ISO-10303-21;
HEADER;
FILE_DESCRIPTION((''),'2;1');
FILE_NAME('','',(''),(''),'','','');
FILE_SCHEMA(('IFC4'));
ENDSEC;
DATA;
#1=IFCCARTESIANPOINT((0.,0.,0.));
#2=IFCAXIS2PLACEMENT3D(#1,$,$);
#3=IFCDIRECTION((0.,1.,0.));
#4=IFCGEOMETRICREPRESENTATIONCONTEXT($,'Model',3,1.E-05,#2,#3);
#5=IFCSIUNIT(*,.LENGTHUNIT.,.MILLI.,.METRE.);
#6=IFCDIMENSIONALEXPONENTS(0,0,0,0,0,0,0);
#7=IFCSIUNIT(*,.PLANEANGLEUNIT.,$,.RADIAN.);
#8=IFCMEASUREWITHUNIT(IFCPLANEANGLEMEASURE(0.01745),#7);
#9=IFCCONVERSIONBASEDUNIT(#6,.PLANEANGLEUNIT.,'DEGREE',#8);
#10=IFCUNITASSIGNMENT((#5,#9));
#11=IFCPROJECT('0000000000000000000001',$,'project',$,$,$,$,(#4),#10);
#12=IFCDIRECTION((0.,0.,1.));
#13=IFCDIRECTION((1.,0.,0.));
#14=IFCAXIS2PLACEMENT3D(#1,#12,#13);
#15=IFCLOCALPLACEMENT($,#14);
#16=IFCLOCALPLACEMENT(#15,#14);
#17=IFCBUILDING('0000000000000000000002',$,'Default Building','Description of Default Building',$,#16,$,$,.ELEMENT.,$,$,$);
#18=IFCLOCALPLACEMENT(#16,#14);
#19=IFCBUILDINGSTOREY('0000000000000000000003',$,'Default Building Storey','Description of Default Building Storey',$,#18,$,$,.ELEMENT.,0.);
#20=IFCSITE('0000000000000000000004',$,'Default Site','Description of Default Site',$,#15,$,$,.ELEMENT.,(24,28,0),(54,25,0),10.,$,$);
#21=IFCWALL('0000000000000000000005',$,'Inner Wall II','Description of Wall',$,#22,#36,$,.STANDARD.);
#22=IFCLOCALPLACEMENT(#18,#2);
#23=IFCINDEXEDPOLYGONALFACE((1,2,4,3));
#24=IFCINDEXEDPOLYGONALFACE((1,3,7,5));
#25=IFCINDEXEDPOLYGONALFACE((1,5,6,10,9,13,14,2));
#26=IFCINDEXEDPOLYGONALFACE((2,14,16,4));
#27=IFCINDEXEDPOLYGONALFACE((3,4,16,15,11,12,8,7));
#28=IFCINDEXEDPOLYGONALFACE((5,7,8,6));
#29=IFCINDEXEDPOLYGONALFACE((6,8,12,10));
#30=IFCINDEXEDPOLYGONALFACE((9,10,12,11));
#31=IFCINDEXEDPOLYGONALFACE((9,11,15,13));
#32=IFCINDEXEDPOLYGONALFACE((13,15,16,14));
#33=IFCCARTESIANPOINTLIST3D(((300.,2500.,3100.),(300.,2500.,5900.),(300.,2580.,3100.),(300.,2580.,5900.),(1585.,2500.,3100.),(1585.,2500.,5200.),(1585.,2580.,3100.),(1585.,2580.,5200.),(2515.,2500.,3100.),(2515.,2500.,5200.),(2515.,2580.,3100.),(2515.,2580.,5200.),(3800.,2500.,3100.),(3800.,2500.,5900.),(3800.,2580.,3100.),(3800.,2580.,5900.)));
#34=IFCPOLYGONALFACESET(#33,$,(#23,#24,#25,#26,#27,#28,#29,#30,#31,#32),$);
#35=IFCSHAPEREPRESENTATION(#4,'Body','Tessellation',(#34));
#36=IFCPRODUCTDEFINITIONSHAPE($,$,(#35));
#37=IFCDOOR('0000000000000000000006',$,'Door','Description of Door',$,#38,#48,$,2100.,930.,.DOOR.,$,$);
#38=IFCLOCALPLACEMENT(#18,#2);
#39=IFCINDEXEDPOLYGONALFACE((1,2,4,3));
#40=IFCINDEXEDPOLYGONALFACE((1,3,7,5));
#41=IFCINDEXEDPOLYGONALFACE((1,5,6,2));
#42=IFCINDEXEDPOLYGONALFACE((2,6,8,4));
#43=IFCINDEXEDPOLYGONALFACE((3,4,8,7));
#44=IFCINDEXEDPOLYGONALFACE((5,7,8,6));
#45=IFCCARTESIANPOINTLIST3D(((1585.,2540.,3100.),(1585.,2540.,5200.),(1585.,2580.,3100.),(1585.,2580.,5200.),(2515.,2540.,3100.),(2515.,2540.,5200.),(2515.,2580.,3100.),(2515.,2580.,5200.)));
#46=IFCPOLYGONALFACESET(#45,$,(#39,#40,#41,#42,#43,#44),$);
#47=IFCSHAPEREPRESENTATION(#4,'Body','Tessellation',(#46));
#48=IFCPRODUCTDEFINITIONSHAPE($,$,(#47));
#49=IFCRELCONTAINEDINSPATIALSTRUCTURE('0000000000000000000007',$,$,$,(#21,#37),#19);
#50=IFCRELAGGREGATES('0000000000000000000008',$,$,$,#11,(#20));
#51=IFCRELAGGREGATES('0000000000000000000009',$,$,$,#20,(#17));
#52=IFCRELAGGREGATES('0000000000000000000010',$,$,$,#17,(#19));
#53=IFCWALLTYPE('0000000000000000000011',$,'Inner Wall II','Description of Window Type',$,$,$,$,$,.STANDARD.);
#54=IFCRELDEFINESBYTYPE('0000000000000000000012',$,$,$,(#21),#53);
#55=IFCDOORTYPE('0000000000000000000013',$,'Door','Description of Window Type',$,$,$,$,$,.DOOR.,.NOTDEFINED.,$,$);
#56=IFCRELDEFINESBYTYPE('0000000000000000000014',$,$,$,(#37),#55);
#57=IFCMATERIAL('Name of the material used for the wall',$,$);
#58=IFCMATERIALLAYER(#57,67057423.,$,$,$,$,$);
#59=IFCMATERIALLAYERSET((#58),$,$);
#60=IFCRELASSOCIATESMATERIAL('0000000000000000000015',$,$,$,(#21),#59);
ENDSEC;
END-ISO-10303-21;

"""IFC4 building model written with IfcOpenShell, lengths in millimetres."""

from ifc_helpers import new_model, entity, si_unit, converted_unit, direction, frame, origin, origin_with_axes, place, context, project, spatial, polyline, outline, extrude, material, layer, layer_set, layer_usage, type_object, element, fill, save


model = new_model("IFC4")

# Units and contexts
model_context = context("Model", 3, precision=1e-05, world=origin(), true_north=direction((0.0, 1.0, 0.0)))
ifc_project = project(units=[si_unit("LENGTHUNIT", "METRE", prefix="MILLI"), converted_unit("PLANEANGLEUNIT", "DEGREE", entity("IfcPlaneAngleMeasure", 0.01745), si_unit("PLANEANGLEUNIT", "RADIAN"), dimensions=[0, 0, 0, 0, 0, 0, 0])], contexts=[model_context])

# Site, building, storey
site_placement = place(None, origin_with_axes())
site = spatial("IfcSite", under=ifc_project, at=site_placement, Name="Default Site", Description="Description of Default Site", CompositionType="ELEMENT", RefLatitude=(24, 28, 0), RefLongitude=(54, 25, 0), RefElevation=10.0)
building_placement = place(site_placement, origin_with_axes())
building = spatial("IfcBuilding", under=site, at=building_placement, Name="Default Building", Description="Description of Default Building", CompositionType="ELEMENT")
storey_placement = place(building_placement, origin_with_axes())
storey = spatial("IfcBuildingStorey", under=building, at=storey_placement, Name="Default Building Storey", Description="Description of Default Building Storey", CompositionType="ELEMENT", Elevation=0.0)

# Wall, opening, door
ifc_material_1 = material(Name="Name of the material used for the wall")
ifc_layer_1 = layer(ifc_material_1, 67057423.0)
ifc_layer_set_1 = layer_set([ifc_layer_1])
ifc_layer_usage_1 = layer_usage(ifc_layer_set_1, "AXIS2", "POSITIVE", -33528711.5)
wall_type_1 = type_object("IfcWallType", Name="Inner Wall II", Description="Description of Window Type", PredefinedType="STANDARD")
wall_1_placement = place(storey_placement, frame((3800.0, 2540.0, 3100.0), z_axis=(0.0, 0.0, 1.0), x_axis=(-1.0, 0.0, 0.0)))
wall_1 = element("IfcWall", 1, at=wall_1_placement, inside=storey, type_object=wall_type_1, material=ifc_layer_usage_1, Name="Inner Wall II", Description="Description of Wall", PredefinedType="STANDARD", context=model_context, shape_type="SweptSolid", body=[
    extrude(outline(polyline([(0.0, -40.0), (0.0, 40.0), (3500.0, 40.0), (3500.0, -40.0), (0.0, -40.0)])), origin_with_axes(), (0.0, 0.0, 1.0), 2800.0),
])
opening_1_placement = place(wall_1_placement, frame((1285.0, -40.0, 0.0), z_axis=(0.0, 0.0, 1.0), x_axis=(1.0, 0.0, 0.0)))
opening_1 = element("IfcOpeningElement", 2, at=opening_1_placement, cuts=wall_1, context=model_context, shape_type="SweptSolid", body=[
    extrude(outline(polyline([(0.0, 0.0), (0.0, 80.0), (930.0, 80.0), (930.0, 0.0), (0.0, 0.0)])), origin_with_axes(), (0.0, 0.0, 1.0), 2100.0),
])
door_type_1 = type_object("IfcDoorType", Name="Door", Description="Description of Window Type", PredefinedType="DOOR")
door_1_placement = place(opening_1_placement, origin_with_axes())
door_1 = element("IfcDoor", 3, at=door_1_placement, inside=storey, type_object=door_type_1, Name="Door", Description="Description of Door", OverallHeight=2100.0, OverallWidth=930.0, PredefinedType="DOOR", context=model_context, shape_type="SweptSolid", body=[
    extrude(outline(polyline([(0.0, 0.0), (0.0, 40.0), (930.0, 40.0), (930.0, 0.0), (0.0, 0.0)])), origin_with_axes(), (0.0, 0.0, 1.0), 2100.0),
])
fill(opening_1, door_1)

save(model, "model.ifc")
